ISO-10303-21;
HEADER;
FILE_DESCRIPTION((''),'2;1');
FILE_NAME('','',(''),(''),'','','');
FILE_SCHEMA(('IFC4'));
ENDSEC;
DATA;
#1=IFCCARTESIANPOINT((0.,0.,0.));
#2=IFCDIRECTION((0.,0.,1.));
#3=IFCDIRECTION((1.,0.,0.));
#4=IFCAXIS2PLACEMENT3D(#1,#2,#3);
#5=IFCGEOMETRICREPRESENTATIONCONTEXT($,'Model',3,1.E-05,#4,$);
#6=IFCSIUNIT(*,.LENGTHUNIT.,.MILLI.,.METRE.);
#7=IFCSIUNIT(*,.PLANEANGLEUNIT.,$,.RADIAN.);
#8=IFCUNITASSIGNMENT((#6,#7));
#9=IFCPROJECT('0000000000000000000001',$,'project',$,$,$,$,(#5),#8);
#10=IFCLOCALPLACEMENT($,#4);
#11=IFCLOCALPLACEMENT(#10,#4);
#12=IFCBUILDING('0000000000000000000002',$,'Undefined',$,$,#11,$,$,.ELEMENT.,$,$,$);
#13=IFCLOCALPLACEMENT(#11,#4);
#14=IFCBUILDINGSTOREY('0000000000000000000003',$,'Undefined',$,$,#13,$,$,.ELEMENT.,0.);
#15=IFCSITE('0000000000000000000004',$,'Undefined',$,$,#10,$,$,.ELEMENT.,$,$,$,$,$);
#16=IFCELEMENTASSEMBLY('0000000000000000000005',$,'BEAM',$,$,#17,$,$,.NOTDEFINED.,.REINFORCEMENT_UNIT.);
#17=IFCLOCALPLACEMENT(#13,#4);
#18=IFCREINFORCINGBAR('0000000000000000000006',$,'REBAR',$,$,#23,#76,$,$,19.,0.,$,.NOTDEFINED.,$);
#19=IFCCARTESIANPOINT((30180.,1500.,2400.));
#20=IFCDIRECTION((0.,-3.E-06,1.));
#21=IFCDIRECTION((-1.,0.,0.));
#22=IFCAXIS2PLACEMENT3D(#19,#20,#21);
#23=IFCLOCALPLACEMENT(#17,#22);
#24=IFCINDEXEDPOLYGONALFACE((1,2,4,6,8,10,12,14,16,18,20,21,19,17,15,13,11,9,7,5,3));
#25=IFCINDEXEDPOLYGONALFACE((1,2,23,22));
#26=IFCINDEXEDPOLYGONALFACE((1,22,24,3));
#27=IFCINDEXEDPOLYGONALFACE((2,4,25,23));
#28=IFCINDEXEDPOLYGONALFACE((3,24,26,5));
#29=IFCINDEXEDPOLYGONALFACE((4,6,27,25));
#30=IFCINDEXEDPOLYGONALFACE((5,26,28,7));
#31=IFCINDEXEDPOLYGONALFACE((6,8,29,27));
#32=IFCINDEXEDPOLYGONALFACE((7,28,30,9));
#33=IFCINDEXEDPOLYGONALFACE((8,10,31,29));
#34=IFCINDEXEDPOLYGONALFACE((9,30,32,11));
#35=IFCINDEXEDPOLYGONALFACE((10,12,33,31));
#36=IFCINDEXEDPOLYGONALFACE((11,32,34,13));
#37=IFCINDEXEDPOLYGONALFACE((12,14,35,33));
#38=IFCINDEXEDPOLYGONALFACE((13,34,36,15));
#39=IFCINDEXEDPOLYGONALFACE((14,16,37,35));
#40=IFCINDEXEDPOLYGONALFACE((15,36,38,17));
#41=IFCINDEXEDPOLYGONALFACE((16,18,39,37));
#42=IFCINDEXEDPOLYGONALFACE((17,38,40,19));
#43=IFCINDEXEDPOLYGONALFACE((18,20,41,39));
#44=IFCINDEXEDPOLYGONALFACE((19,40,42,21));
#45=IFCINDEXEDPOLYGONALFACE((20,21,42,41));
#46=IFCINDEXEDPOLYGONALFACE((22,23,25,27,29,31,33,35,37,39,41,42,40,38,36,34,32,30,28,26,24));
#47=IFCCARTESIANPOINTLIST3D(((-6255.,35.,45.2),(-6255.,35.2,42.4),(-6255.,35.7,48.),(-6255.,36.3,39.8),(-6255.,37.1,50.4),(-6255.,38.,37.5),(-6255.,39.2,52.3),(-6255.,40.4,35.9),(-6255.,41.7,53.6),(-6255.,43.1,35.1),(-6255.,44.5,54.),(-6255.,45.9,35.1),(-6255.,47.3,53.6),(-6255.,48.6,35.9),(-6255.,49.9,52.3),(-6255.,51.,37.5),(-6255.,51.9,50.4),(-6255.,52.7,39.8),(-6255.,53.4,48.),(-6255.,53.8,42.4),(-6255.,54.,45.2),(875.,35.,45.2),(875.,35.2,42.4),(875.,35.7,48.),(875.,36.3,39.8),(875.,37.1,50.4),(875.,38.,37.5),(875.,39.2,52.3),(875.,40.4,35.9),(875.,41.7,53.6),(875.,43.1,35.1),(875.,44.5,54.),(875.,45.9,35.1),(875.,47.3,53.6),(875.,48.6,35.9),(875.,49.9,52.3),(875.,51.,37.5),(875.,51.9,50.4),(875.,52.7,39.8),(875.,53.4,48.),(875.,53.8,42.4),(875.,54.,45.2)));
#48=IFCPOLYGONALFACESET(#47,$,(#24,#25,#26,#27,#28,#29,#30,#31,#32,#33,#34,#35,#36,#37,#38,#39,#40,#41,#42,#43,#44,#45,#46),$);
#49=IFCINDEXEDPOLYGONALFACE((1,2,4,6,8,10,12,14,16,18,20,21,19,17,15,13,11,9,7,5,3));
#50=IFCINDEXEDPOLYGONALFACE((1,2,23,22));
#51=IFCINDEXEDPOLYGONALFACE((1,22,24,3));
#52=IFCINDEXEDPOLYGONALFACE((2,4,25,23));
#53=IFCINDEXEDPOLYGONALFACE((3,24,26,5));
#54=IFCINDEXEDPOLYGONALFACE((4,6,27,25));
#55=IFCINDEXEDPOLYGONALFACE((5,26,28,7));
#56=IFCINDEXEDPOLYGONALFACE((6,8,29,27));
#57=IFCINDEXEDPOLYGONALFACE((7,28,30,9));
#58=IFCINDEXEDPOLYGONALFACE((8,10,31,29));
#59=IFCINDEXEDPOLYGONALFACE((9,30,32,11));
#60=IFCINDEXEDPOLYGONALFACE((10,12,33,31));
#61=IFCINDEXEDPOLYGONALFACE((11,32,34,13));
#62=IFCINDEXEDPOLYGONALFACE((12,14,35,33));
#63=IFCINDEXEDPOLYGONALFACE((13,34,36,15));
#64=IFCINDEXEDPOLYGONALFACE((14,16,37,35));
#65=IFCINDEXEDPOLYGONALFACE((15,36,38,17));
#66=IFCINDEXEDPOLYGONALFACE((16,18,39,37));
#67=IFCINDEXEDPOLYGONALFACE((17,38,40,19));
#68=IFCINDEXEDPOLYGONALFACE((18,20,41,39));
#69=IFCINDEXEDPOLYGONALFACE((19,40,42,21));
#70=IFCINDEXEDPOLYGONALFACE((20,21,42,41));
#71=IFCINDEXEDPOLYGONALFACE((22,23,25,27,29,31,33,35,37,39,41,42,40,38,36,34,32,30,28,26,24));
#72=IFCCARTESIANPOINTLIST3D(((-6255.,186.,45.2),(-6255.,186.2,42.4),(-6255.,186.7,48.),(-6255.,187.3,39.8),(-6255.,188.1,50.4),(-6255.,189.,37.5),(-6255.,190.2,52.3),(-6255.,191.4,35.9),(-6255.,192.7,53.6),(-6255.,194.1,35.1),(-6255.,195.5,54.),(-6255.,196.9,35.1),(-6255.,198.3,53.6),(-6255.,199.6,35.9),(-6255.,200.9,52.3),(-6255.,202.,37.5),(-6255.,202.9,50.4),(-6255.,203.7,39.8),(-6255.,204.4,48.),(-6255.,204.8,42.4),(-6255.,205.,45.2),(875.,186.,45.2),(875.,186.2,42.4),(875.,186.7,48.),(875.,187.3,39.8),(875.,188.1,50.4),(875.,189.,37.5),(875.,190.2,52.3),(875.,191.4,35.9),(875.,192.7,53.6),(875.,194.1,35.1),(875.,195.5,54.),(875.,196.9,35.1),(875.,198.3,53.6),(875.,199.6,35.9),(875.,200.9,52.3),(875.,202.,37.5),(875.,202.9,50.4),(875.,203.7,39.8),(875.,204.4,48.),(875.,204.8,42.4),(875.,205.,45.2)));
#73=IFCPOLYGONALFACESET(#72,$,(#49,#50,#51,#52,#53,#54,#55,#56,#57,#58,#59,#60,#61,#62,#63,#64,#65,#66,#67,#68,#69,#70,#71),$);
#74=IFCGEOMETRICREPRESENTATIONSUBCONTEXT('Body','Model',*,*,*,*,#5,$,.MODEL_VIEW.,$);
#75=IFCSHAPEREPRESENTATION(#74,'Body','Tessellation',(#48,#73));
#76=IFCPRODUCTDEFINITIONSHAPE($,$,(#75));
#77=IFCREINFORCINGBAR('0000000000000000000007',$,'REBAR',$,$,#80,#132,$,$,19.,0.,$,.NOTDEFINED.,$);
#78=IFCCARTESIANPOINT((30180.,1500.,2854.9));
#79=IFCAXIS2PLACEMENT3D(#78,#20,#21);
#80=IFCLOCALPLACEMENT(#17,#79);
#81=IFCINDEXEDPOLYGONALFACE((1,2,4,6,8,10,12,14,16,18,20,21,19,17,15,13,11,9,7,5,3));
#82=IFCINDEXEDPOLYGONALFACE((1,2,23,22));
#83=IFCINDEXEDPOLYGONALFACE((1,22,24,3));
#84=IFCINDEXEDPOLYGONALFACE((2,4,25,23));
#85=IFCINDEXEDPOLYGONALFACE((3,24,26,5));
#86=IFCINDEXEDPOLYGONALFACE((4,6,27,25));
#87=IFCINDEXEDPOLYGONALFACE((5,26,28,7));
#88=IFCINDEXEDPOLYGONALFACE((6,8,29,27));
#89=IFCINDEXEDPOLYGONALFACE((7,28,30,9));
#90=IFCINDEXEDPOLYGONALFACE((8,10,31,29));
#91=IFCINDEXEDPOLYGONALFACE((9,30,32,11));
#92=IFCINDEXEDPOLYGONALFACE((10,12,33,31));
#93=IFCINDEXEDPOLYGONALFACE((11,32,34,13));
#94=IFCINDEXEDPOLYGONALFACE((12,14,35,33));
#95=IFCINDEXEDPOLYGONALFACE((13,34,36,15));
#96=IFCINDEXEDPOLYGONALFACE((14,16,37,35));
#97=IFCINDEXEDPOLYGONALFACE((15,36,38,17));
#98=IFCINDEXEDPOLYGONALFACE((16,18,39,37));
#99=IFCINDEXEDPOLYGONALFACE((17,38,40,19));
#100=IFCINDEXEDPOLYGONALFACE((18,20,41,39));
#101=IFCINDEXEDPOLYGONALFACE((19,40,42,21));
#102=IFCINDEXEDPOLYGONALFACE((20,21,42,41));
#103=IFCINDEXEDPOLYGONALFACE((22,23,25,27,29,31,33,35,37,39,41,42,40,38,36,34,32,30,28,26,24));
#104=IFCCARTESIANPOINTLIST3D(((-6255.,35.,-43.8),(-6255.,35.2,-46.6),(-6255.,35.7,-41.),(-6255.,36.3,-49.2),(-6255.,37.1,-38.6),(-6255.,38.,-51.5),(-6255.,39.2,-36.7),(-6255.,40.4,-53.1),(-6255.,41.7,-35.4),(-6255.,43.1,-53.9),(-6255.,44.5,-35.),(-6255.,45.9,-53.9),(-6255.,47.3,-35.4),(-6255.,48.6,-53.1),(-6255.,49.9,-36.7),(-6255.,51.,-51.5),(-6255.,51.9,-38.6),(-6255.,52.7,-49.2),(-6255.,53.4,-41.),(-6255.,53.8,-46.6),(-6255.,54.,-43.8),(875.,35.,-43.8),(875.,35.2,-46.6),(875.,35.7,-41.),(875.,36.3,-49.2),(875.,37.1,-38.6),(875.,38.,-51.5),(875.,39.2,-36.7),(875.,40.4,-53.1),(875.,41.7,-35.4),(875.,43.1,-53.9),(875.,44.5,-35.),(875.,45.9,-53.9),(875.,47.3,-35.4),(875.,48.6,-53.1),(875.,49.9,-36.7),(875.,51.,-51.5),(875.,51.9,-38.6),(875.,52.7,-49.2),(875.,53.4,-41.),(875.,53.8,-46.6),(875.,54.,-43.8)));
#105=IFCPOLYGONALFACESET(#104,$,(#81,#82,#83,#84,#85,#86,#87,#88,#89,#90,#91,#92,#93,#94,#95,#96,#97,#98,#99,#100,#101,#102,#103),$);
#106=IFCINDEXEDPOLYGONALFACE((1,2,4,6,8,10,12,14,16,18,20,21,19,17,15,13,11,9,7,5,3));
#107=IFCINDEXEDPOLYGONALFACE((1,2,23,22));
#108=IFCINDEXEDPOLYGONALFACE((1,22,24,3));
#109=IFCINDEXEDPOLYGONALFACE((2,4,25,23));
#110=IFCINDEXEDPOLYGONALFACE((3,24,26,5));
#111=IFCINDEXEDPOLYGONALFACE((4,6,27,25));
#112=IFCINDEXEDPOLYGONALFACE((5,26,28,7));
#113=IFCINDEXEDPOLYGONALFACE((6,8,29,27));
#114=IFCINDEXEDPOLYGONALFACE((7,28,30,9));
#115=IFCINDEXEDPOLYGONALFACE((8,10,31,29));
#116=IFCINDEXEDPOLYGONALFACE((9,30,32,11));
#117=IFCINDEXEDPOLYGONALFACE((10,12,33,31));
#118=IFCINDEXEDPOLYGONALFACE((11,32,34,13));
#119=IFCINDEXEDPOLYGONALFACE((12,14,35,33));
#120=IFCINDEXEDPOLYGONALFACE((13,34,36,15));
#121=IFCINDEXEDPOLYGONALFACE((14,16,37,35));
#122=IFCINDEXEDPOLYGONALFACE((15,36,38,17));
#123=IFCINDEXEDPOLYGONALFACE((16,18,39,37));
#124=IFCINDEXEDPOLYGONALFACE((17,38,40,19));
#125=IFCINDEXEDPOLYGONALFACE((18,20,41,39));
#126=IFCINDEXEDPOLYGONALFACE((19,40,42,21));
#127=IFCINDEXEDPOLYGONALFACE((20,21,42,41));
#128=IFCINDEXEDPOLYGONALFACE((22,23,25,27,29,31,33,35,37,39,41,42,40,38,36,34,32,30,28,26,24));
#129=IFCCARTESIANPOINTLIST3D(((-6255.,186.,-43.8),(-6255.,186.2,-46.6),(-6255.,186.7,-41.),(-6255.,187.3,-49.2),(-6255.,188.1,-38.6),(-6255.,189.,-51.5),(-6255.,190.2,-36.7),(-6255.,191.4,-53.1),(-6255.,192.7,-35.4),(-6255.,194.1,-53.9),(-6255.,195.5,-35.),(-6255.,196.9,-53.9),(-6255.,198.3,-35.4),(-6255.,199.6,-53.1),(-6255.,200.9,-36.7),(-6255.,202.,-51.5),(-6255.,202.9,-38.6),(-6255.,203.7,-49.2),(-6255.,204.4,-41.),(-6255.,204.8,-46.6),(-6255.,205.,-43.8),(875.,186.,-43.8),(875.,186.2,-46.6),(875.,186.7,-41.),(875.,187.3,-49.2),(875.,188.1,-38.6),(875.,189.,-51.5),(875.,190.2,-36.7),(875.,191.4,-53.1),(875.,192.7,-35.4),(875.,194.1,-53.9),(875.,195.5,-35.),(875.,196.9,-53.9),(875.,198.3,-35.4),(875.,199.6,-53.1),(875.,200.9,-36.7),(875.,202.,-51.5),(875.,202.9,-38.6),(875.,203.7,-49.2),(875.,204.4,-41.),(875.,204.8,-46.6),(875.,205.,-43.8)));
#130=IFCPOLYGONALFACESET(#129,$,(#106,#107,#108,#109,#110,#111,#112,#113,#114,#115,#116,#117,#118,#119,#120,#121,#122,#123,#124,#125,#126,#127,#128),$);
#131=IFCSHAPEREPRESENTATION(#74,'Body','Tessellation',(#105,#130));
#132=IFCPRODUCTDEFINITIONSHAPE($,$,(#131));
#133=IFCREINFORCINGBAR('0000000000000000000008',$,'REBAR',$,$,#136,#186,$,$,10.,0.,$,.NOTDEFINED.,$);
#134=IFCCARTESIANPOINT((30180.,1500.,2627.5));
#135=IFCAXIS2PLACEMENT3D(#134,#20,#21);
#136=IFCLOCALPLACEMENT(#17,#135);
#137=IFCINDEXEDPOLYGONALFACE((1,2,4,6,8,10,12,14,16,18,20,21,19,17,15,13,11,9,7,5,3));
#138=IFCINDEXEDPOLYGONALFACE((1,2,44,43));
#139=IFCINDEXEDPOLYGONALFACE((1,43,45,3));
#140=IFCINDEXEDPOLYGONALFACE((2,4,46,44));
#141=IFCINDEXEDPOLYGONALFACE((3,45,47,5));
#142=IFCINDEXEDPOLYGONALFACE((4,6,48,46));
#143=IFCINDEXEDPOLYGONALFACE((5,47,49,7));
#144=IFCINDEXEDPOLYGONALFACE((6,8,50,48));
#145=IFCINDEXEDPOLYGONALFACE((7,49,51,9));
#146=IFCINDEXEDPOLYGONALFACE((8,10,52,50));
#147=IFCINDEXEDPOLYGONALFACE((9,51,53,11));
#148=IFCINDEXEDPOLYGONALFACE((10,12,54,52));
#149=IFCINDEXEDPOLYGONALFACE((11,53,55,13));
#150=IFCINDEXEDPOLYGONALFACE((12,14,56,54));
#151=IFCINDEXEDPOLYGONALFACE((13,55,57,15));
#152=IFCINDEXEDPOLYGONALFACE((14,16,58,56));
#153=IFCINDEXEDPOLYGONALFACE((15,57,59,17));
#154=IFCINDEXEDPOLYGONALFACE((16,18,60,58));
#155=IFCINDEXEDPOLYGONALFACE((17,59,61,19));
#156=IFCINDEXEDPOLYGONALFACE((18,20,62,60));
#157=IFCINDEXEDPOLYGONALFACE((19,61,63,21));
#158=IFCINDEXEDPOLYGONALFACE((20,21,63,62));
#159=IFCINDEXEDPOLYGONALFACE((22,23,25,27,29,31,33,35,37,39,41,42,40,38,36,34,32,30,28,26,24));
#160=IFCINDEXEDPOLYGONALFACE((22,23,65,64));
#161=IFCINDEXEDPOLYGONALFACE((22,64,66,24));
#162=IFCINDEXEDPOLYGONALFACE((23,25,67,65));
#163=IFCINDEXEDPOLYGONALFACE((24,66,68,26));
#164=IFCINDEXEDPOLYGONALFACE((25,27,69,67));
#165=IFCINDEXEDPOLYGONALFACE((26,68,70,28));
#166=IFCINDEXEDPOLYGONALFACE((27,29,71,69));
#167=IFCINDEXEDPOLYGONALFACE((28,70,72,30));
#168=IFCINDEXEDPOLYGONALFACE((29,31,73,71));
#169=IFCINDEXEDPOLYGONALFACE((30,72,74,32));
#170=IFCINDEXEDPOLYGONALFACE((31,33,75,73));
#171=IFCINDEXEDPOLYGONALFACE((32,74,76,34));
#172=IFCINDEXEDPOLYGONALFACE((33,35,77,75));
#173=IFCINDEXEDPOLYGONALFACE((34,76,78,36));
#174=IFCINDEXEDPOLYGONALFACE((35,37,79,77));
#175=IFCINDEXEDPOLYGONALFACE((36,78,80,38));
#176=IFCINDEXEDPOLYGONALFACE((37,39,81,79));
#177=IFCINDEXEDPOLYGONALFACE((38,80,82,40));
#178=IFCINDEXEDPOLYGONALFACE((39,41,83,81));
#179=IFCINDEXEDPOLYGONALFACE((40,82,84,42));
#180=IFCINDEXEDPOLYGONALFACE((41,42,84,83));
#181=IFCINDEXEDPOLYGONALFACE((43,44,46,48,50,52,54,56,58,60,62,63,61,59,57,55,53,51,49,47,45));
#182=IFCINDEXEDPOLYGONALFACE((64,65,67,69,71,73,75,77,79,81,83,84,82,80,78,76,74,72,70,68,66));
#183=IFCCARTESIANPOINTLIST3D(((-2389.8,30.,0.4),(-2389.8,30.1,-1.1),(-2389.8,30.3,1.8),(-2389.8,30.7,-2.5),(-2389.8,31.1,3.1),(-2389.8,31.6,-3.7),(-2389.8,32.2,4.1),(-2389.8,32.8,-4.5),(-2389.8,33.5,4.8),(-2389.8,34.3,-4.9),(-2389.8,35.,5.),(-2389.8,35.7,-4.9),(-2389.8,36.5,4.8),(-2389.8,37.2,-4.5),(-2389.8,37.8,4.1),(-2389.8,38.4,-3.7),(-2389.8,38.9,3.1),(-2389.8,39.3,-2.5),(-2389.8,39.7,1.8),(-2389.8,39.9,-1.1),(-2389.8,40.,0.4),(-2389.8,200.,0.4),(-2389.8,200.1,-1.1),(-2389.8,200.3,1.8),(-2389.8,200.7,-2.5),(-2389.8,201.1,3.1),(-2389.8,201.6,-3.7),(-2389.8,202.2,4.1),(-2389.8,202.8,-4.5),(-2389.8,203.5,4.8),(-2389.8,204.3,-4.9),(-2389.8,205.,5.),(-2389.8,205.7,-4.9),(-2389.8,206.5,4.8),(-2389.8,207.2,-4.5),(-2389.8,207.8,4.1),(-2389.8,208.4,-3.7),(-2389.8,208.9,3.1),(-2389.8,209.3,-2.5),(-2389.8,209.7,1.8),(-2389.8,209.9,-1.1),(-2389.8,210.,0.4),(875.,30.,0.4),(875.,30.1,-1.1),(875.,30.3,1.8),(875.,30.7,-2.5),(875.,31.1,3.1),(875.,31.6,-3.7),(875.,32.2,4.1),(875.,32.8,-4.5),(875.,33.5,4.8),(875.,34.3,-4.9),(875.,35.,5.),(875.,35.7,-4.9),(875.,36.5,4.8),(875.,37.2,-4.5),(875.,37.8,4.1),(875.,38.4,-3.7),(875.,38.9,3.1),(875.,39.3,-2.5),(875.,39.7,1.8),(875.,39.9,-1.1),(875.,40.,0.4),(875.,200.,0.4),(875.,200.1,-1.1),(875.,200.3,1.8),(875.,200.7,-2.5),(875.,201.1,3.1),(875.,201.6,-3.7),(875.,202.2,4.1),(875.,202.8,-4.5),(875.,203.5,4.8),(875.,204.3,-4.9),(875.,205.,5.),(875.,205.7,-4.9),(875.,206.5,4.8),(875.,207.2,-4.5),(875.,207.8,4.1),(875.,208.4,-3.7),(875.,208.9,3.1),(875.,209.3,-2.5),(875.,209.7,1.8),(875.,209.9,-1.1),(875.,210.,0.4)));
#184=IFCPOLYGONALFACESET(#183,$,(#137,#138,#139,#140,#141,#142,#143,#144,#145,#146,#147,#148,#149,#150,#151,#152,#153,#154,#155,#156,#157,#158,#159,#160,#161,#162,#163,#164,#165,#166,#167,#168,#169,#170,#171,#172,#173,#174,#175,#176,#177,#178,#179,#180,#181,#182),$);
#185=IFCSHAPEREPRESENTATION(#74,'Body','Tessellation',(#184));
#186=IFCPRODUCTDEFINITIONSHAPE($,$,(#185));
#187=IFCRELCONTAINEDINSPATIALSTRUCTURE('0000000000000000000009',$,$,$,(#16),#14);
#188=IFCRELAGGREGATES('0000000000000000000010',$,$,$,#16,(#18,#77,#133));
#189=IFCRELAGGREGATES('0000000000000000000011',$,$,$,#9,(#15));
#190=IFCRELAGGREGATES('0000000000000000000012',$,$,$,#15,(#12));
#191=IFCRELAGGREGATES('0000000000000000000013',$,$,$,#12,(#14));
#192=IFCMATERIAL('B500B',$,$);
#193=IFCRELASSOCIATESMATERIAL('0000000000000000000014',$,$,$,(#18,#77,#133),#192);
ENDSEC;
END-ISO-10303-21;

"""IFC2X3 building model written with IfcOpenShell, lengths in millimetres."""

from ifc_helpers import new_model, entity, si_unit, frame, origin_with_axes, place, context, subcontext, project, spatial, source, transform, mapped, material, element, aggregate, save


model = new_model("IFC2X3")

# Units and contexts
model_context = context("Model", 3, precision=1e-05, world=origin_with_axes())
body_context = subcontext(model_context, "Body", "Model", "MODEL_VIEW")
ifc_project = project(units=[si_unit("LENGTHUNIT", "METRE", prefix="MILLI"), si_unit("PLANEANGLEUNIT", "RADIAN")], contexts=[model_context])

# Site, building, storey
site_placement = place(None, origin_with_axes())
site = spatial("IfcSite", under=ifc_project, at=site_placement, Name="Undefined", CompositionType="ELEMENT")
building_placement = place(site_placement, origin_with_axes())
building = spatial("IfcBuilding", under=site, at=building_placement, Name="Undefined", CompositionType="ELEMENT")
storey_placement = place(building_placement, origin_with_axes())
storey = spatial("IfcBuildingStorey", under=building, at=storey_placement, Name="Undefined", CompositionType="ELEMENT", Elevation=0.0)

# Element assembly
assembly_1_placement = place(storey_placement, origin_with_axes())
assembly_1 = element("IfcElementAssembly", 1, at=assembly_1_placement, inside=storey, Name="BEAM", AssemblyPlace="NOTDEFINED", PredefinedType="REINFORCEMENT_UNIT")

# Reinforcing bars
ifc_material_1 = material(Name="B500B")
shared_shape_1 = source(origin_with_axes(), body_context, "Body", "AdvancedSweptSolid", [
    entity("IfcSweptDiskSolid", entity("IfcTrimmedCurve", entity("IfcLine", entity("IfcCartesianPoint", [0.0, 0.0, 0.0]), entity("IfcVector", entity("IfcDirection", [1.0, 0.0, 0.0]), 1.0)), [entity("IfcParameterValue", 0.0)], [entity("IfcParameterValue", 7130.022833)], True, "PARAMETER"), 9.5, None, 0.0, 7130.0),
])
shared_shape_2 = source(origin_with_axes(), body_context, "Body", "AdvancedSweptSolid", [
    entity("IfcSweptDiskSolid", entity("IfcTrimmedCurve", entity("IfcLine", entity("IfcCartesianPoint", [0.0, 0.0, 0.0]), entity("IfcVector", entity("IfcDirection", [1.0, 0.0, 0.0]), 1.0)), [entity("IfcParameterValue", 0.0)], [entity("IfcParameterValue", 7130.022833)], True, "PARAMETER"), 9.5, None, 0.0, 7130.0),
])
reinforcing_bar_1_placement = place(assembly_1_placement, frame((30180.0, 1500.0, 2400.0), z_axis=(0.0, -0.000003, 1.0), x_axis=(-1.0, 0.0, 0.0)))
reinforcing_bar_1 = element("IfcReinforcingBar", 2, at=reinforcing_bar_1_placement, material=ifc_material_1, Name="REBAR", BarRole="NOTDEFINED", CrossSectionArea=0.0, NominalDiameter=19.0, context=body_context, shape_type="MappedRepresentation", body=[
    mapped(shared_shape_1, transform((-6255.0, 44.5, 44.5))),
    mapped(shared_shape_2, transform((-6255.0, 195.5, 44.5))),
])
shared_shape_3 = source(origin_with_axes(), body_context, "Body", "AdvancedSweptSolid", [
    entity("IfcSweptDiskSolid", entity("IfcTrimmedCurve", entity("IfcLine", entity("IfcCartesianPoint", [0.0, 0.0, 0.0]), entity("IfcVector", entity("IfcDirection", [1.0, 0.0, 0.0]), 1.0)), [entity("IfcParameterValue", 0.0)], [entity("IfcParameterValue", 7130.022833)], True, "PARAMETER"), 9.5, None, 0.0, 7130.0),
])
shared_shape_4 = source(origin_with_axes(), body_context, "Body", "AdvancedSweptSolid", [
    entity("IfcSweptDiskSolid", entity("IfcTrimmedCurve", entity("IfcLine", entity("IfcCartesianPoint", [0.0, 0.0, 0.0]), entity("IfcVector", entity("IfcDirection", [1.0, 0.0, 0.0]), 1.0)), [entity("IfcParameterValue", 0.0)], [entity("IfcParameterValue", 7130.022833)], True, "PARAMETER"), 9.5, None, 0.0, 7130.0),
])
reinforcing_bar_2_placement = place(assembly_1_placement, frame((30180.0, 1500.0, 2854.9), z_axis=(0.0, -0.000003, 1.0), x_axis=(-1.0, 0.0, 0.0)))
reinforcing_bar_2 = element("IfcReinforcingBar", 3, at=reinforcing_bar_2_placement, material=ifc_material_1, Name="REBAR", BarRole="NOTDEFINED", CrossSectionArea=0.0, NominalDiameter=19.0, context=body_context, shape_type="MappedRepresentation", body=[
    mapped(shared_shape_3, transform((-6255.0, 44.5, -44.5))),
    mapped(shared_shape_4, transform((-6255.0, 195.5, -44.5))),
])
shared_shape_5 = source(origin_with_axes(), body_context, "Body", "AdvancedSweptSolid", [
    entity("IfcSweptDiskSolid", entity("IfcTrimmedCurve", entity("IfcLine", entity("IfcCartesianPoint", [0.0, 0.0, 0.0]), entity("IfcVector", entity("IfcDirection", [1.0, 0.0, 0.0]), 1.0)), [entity("IfcParameterValue", 0.0)], [entity("IfcParameterValue", 3264.782835)], True, "PARAMETER"), 5.0, None, 0.0, 3264.8),
])
shared_shape_6 = source(origin_with_axes(), body_context, "Body", "AdvancedSweptSolid", [
    entity("IfcSweptDiskSolid", entity("IfcTrimmedCurve", entity("IfcLine", entity("IfcCartesianPoint", [0.0, 0.0, 0.0]), entity("IfcVector", entity("IfcDirection", [1.0, 0.0, 0.0]), 1.0)), [entity("IfcParameterValue", 0.0)], [entity("IfcParameterValue", 3264.782835)], True, "PARAMETER"), 5.0, None, 0.0, 3264.8),
])
reinforcing_bar_3_placement = place(assembly_1_placement, frame((30180.0, 1500.0, 2627.5), z_axis=(0.0, -0.000003, 1.0), x_axis=(-1.0, 0.0, 0.0)))
reinforcing_bar_3 = element("IfcReinforcingBar", 4, at=reinforcing_bar_3_placement, material=ifc_material_1, Name="REBAR", BarRole="NOTDEFINED", CrossSectionArea=0.0, NominalDiameter=10.0, context=body_context, shape_type="MappedRepresentation", body=[
    mapped(shared_shape_5, transform((-2389.8, 35.0, 0.0))),
    mapped(shared_shape_6, transform((-2389.8, 205.0, 0.0))),
])
aggregate(assembly_1, [reinforcing_bar_1, reinforcing_bar_2, reinforcing_bar_3])

save(model, "model.ifc")
